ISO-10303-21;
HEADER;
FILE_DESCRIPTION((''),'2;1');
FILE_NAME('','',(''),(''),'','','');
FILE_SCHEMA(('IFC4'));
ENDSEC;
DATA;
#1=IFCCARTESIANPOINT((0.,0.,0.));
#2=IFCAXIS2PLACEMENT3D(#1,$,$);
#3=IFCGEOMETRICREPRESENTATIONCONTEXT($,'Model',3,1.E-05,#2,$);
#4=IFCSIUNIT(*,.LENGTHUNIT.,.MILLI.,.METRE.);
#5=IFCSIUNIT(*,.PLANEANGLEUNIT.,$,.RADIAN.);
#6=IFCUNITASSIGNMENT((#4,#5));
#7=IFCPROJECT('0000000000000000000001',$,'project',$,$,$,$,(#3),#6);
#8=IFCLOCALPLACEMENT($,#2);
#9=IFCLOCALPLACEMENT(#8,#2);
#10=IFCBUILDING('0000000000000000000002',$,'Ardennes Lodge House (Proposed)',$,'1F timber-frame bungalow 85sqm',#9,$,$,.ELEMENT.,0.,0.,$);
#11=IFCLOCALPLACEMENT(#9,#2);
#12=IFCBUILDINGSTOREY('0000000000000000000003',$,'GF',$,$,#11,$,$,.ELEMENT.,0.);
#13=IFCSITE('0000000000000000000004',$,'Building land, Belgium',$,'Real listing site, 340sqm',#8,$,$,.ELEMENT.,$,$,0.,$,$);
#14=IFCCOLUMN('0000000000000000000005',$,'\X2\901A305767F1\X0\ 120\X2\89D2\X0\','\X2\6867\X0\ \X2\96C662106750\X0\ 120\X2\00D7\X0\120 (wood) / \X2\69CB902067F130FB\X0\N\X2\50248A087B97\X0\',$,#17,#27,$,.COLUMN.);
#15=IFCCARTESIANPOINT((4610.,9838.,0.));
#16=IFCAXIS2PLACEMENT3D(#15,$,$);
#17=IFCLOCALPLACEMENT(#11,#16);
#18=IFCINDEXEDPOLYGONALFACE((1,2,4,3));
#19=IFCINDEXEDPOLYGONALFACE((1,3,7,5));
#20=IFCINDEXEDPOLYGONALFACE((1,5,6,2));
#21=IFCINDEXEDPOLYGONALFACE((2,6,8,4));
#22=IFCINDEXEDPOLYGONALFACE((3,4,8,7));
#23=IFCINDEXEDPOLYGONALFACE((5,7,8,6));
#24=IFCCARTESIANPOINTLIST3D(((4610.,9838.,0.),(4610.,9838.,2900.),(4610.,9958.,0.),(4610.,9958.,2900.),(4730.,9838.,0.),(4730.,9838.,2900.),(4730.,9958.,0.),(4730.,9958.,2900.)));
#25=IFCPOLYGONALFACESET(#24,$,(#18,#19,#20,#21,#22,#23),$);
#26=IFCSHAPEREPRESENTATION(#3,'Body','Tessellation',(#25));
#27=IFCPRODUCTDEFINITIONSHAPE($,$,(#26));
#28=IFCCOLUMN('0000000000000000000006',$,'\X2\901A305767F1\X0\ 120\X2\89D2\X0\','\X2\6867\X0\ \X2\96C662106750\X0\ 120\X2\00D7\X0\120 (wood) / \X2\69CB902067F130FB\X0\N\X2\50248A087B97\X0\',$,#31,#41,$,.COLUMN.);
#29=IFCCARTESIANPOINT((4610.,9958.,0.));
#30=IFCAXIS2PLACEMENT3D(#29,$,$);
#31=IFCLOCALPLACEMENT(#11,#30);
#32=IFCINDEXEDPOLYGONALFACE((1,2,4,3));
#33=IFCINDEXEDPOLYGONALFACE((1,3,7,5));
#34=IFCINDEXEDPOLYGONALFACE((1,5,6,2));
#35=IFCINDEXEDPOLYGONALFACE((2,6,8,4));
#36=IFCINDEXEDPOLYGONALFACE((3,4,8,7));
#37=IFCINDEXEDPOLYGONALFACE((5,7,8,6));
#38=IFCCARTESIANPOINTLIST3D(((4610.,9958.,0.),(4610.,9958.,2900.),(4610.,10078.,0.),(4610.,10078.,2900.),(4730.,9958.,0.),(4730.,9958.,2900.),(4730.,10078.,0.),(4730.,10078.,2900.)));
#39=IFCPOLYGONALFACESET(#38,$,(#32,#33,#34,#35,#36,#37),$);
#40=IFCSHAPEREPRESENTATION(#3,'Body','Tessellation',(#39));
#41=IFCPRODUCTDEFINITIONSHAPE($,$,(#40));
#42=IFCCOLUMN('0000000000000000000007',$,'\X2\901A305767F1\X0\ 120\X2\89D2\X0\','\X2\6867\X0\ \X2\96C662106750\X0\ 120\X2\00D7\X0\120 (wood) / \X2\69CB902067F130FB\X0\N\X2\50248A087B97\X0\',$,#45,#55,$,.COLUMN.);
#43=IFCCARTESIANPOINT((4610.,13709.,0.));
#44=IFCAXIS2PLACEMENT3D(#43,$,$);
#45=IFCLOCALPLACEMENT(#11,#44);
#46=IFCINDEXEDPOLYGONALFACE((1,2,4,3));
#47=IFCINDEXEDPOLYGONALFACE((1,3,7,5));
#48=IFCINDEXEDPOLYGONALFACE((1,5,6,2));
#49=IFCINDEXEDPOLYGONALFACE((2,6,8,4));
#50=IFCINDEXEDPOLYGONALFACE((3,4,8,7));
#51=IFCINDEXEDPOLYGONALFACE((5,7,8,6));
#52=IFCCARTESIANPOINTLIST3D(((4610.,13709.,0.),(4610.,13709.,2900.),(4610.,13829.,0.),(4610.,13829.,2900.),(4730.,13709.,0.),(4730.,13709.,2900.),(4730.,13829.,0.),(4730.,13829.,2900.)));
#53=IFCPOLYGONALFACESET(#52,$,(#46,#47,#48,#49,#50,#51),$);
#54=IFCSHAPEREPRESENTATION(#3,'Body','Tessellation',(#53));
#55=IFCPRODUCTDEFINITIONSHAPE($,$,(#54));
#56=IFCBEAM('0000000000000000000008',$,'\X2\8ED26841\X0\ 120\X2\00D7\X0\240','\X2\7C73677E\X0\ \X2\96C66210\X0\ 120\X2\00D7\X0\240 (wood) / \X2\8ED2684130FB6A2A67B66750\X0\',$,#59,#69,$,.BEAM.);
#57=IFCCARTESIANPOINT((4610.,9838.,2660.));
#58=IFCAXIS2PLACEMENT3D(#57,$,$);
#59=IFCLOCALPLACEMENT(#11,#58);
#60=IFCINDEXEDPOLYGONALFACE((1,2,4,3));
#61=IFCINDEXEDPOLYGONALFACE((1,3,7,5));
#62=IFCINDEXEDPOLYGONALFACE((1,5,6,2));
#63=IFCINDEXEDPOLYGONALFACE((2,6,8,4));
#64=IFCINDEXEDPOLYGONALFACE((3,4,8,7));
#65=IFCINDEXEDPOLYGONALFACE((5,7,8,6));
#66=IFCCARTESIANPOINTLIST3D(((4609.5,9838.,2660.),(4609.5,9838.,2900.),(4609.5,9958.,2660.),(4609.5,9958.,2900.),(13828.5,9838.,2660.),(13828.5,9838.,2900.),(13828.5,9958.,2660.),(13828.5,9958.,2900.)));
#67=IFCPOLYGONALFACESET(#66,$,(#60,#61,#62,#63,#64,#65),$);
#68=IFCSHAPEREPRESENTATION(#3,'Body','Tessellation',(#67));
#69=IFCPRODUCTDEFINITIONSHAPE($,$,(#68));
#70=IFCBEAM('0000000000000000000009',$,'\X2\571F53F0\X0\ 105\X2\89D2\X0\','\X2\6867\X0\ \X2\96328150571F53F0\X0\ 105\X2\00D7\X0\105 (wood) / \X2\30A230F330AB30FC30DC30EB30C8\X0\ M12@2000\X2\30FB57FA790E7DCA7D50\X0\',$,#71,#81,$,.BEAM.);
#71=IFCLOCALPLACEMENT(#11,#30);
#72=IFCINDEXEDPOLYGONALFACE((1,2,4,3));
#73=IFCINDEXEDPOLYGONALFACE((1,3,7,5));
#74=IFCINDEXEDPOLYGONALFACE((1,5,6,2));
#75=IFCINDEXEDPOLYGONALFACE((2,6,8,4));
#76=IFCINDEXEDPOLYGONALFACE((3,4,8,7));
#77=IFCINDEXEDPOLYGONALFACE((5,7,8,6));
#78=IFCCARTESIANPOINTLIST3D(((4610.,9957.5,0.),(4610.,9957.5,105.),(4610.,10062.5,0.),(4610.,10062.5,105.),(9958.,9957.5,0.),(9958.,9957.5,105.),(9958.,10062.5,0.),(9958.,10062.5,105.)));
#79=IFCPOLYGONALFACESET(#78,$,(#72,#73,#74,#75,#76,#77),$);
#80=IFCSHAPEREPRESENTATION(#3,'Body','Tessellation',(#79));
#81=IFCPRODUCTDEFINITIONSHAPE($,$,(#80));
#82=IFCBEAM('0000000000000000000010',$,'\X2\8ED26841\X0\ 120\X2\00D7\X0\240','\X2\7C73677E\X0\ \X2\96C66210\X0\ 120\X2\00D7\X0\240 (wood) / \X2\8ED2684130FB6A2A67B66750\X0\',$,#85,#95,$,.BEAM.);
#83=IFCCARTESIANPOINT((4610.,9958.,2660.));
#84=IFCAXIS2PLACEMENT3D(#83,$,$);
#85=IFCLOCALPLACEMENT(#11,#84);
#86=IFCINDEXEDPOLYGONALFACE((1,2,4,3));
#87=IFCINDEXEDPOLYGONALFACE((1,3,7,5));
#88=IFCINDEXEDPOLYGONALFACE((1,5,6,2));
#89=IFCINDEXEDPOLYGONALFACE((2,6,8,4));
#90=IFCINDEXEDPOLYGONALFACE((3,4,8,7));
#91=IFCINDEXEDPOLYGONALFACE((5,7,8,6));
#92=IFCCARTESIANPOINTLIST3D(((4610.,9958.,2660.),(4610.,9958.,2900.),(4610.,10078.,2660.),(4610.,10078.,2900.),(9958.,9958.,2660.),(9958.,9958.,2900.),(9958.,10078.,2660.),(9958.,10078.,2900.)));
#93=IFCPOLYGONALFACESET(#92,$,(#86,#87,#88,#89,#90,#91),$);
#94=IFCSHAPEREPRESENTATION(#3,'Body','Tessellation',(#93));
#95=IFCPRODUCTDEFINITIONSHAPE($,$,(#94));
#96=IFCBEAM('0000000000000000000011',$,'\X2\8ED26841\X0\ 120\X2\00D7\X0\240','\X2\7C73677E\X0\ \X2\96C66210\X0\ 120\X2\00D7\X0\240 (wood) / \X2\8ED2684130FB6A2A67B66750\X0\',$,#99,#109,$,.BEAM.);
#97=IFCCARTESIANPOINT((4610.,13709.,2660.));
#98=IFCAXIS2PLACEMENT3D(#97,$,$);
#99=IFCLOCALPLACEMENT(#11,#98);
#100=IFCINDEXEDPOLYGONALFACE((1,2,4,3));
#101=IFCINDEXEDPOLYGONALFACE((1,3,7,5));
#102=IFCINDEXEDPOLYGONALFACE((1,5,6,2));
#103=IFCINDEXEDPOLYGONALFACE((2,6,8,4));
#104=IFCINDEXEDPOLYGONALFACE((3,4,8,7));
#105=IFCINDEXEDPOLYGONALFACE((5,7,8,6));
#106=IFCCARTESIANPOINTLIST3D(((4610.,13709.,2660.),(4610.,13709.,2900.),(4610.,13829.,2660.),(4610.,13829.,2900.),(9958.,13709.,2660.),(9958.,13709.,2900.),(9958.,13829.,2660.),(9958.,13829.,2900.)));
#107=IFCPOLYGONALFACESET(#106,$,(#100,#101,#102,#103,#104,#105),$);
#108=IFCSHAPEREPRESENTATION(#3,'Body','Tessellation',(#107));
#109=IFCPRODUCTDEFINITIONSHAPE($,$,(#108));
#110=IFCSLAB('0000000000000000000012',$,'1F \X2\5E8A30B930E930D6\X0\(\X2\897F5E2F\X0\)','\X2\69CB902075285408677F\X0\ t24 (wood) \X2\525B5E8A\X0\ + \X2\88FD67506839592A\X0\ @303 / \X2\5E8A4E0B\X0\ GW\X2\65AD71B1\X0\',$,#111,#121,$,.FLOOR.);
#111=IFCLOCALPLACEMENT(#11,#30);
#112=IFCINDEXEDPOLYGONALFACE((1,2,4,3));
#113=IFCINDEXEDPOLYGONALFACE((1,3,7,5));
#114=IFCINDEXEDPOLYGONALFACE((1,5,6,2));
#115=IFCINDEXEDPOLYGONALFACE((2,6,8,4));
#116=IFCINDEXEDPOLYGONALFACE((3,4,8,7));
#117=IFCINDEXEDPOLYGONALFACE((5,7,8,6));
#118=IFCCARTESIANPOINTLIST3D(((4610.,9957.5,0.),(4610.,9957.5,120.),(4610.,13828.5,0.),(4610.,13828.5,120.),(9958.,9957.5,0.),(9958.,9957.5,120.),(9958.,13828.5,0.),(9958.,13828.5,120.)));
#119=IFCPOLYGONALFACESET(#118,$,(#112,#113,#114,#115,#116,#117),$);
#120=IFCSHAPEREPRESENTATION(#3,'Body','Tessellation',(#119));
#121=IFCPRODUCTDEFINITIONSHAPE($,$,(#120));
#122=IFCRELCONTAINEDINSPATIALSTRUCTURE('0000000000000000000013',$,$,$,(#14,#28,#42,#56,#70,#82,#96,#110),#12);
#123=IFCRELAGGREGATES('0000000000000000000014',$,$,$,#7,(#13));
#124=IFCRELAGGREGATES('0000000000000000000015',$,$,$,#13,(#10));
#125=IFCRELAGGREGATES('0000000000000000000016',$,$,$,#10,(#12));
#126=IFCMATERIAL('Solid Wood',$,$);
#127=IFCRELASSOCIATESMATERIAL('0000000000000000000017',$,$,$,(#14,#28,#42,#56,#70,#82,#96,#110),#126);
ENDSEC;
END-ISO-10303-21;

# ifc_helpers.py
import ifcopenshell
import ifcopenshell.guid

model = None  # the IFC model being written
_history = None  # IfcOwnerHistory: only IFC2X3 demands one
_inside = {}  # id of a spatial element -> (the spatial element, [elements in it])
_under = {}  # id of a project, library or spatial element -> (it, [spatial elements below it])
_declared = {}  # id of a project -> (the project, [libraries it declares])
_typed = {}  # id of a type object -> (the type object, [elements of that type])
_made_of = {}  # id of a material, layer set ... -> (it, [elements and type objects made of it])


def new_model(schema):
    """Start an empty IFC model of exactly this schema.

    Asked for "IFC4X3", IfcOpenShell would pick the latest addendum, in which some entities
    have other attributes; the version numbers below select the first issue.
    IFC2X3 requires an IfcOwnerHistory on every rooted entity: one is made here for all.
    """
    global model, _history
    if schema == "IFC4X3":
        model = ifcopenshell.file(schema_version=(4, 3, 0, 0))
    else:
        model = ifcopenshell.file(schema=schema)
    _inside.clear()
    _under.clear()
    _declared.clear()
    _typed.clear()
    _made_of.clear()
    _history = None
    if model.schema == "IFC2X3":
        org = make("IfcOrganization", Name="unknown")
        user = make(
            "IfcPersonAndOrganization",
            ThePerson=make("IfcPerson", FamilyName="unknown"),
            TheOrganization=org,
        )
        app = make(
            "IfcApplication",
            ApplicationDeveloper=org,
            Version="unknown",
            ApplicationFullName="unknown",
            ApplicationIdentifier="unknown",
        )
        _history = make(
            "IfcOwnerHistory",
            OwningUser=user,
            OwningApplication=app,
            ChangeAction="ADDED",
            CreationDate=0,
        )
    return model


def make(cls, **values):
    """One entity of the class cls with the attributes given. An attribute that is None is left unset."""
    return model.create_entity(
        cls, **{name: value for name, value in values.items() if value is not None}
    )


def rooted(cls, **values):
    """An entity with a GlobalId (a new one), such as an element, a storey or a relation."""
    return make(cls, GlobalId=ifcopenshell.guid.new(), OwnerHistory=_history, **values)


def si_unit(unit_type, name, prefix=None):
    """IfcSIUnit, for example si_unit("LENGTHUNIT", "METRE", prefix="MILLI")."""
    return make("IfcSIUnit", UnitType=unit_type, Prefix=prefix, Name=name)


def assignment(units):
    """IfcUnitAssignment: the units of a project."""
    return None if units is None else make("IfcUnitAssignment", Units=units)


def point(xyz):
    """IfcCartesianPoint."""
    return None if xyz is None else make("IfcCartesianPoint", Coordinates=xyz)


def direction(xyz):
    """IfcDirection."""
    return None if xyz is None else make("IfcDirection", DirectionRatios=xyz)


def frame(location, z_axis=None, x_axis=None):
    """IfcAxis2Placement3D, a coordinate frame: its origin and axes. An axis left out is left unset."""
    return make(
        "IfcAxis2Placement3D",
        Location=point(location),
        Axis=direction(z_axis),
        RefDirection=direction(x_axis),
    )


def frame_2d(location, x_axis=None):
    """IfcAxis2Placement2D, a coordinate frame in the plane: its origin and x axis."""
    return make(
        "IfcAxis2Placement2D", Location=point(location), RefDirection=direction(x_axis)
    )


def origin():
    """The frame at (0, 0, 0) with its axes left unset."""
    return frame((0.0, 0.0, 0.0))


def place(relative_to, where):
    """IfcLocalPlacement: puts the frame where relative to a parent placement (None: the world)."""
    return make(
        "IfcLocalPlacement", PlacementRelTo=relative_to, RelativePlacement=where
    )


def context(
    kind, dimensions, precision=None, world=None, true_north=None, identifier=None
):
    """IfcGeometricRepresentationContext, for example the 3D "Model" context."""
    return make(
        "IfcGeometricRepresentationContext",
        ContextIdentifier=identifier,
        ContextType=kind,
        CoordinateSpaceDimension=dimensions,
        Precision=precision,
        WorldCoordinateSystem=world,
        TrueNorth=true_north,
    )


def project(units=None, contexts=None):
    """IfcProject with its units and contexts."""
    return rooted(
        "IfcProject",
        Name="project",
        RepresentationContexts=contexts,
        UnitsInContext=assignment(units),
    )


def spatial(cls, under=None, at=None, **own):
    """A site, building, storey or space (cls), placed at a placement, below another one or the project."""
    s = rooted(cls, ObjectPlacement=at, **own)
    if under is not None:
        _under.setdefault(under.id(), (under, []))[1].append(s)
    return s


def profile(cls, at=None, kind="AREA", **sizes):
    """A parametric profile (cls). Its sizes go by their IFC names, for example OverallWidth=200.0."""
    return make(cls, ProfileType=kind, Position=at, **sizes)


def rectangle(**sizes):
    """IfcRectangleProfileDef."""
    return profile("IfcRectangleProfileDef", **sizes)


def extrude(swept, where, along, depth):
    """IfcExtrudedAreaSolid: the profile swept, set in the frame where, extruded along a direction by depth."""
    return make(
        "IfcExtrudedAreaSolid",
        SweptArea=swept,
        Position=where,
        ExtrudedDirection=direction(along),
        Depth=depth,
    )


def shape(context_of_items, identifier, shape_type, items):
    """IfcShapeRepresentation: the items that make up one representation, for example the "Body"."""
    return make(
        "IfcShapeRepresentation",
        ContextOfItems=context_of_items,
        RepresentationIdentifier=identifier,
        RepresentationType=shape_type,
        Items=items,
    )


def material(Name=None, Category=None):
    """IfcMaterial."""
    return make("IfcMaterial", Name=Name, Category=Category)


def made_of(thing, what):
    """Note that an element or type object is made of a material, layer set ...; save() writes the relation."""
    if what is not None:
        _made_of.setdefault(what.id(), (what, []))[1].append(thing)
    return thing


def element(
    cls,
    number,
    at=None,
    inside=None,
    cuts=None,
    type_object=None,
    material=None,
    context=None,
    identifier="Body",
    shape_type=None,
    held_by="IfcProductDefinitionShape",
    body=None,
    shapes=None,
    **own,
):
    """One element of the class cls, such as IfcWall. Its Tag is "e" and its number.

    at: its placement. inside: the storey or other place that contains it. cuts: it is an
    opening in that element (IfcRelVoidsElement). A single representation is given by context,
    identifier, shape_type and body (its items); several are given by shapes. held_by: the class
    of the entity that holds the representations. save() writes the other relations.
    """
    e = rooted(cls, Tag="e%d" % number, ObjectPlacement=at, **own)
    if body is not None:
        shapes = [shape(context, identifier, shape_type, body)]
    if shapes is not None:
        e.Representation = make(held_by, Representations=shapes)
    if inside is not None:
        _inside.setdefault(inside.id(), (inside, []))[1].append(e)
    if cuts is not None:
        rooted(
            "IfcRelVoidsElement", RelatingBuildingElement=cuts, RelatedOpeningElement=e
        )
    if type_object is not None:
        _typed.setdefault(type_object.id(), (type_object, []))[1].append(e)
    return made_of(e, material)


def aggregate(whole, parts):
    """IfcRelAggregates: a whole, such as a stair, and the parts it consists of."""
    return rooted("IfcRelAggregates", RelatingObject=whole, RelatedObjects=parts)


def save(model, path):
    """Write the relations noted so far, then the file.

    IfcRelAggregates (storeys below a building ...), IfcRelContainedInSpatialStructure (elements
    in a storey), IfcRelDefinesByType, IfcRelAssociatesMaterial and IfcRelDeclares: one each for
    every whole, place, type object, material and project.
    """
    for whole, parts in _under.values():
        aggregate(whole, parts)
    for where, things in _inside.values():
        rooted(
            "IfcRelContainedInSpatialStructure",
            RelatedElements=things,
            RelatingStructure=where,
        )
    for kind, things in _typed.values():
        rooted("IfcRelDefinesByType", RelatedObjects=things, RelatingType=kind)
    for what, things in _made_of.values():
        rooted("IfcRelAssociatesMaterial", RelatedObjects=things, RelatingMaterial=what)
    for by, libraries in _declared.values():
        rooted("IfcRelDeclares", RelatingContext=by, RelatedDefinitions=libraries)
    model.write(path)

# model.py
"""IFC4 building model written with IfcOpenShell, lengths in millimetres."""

from ifc_helpers import new_model, si_unit, frame, frame_2d, origin, place, context, project, spatial, rectangle, extrude, material, element, save


model = new_model("IFC4")

# Units and contexts
model_context = context("Model", 3, precision=1e-05, world=origin())
ifc_project = project(units=[si_unit("LENGTHUNIT", "METRE", prefix="MILLI"), si_unit("PLANEANGLEUNIT", "RADIAN")], contexts=[model_context])

# Site, building, storey
site_placement = place(None, origin())
site = spatial("IfcSite", under=ifc_project, at=site_placement, Name="Building land, Belgium", ObjectType="Real listing site, 340sqm", CompositionType="ELEMENT", RefElevation=0.0)
building_placement = place(site_placement, origin())
building = spatial("IfcBuilding", under=site, at=building_placement, Name="Ardennes Lodge House (Proposed)", ObjectType="1F timber-frame bungalow 85sqm", CompositionType="ELEMENT", ElevationOfRefHeight=0.0, ElevationOfTerrain=0.0)
storey_placement = place(building_placement, origin())
storey = spatial("IfcBuildingStorey", under=building, at=storey_placement, Name="GF", CompositionType="ELEMENT", Elevation=0.0)

# Columns
ifc_material_1 = material(Name="Solid Wood")
column_1_placement = place(storey_placement, frame((4610.0, 9838.0, 0.0)))
element("IfcColumn", 1, at=column_1_placement, inside=storey, material=ifc_material_1, Name="通し柱 120角", Description="桧 集成材 120×120 (wood) / 構造柱・N値計算", PredefinedType="COLUMN", context=model_context, shape_type="SweptSolid", body=[
    extrude(rectangle(XDim=120.0, YDim=120.0, at=frame_2d((60.0, 60.0))), frame((4610.0, 9838.0, 0.0)), (0.0, 0.0, 1.0), 2900.0),
])
column_2_placement = place(storey_placement, frame((4610.0, 9958.0, 0.0)))
element("IfcColumn", 2, at=column_2_placement, inside=storey, material=ifc_material_1, Name="通し柱 120角", Description="桧 集成材 120×120 (wood) / 構造柱・N値計算", PredefinedType="COLUMN", context=model_context, shape_type="SweptSolid", body=[
    extrude(rectangle(XDim=120.0, YDim=120.0, at=frame_2d((60.0, 60.0))), frame((4610.0, 9958.0, 0.0)), (0.0, 0.0, 1.0), 2900.0),
])
column_3_placement = place(storey_placement, frame((4610.0, 13709.0, 0.0)))
element("IfcColumn", 3, at=column_3_placement, inside=storey, material=ifc_material_1, Name="通し柱 120角", Description="桧 集成材 120×120 (wood) / 構造柱・N値計算", PredefinedType="COLUMN", context=model_context, shape_type="SweptSolid", body=[
    extrude(rectangle(XDim=120.0, YDim=120.0, at=frame_2d((60.0, 60.0))), frame((4610.0, 13709.0, 0.0)), (0.0, 0.0, 1.0), 2900.0),
])

# Beams
beam_1_placement = place(storey_placement, frame((4610.0, 9838.0, 2660.0)))
element("IfcBeam", 4, at=beam_1_placement, inside=storey, material=ifc_material_1, Name="軒桁 120×240", Description="米松 集成 120×240 (wood) / 軒桁・横架材", PredefinedType="BEAM", context=model_context, shape_type="SweptSolid", body=[
    extrude(rectangle(XDim=9219.0, YDim=120.0, at=frame_2d((4609.0, 60.0))), frame((4610.0, 9838.0, 2660.0)), (0.0, 0.0, 1.0), 240.0),
])
beam_2_placement = place(storey_placement, frame((4610.0, 9958.0, 0.0)))
element("IfcBeam", 5, at=beam_2_placement, inside=storey, material=ifc_material_1, Name="土台 105角", Description="桧 防腐土台 105×105 (wood) / アンカーボルト M12@2000・基礎緊結", PredefinedType="BEAM", context=model_context, shape_type="SweptSolid", body=[
    extrude(rectangle(XDim=5348.0, YDim=105.0, at=frame_2d((2674.0, 52.0))), frame((4610.0, 9958.0, 0.0)), (0.0, 0.0, 1.0), 105.0),
])
beam_3_placement = place(storey_placement, frame((4610.0, 9958.0, 2660.0)))
element("IfcBeam", 6, at=beam_3_placement, inside=storey, material=ifc_material_1, Name="軒桁 120×240", Description="米松 集成 120×240 (wood) / 軒桁・横架材", PredefinedType="BEAM", context=model_context, shape_type="SweptSolid", body=[
    extrude(rectangle(XDim=5348.0, YDim=120.0, at=frame_2d((2674.0, 60.0))), frame((4610.0, 9958.0, 2660.0)), (0.0, 0.0, 1.0), 240.0),
])
beam_4_placement = place(storey_placement, frame((4610.0, 13709.0, 2660.0)))
element("IfcBeam", 7, at=beam_4_placement, inside=storey, material=ifc_material_1, Name="軒桁 120×240", Description="米松 集成 120×240 (wood) / 軒桁・横架材", PredefinedType="BEAM", context=model_context, shape_type="SweptSolid", body=[
    extrude(rectangle(XDim=5348.0, YDim=120.0, at=frame_2d((2674.0, 60.0))), frame((4610.0, 13709.0, 2660.0)), (0.0, 0.0, 1.0), 240.0),
])

# Slab
slab_placement = place(storey_placement, frame((4610.0, 9958.0, 0.0)))
element("IfcSlab", 8, at=slab_placement, inside=storey, material=ifc_material_1, Name="1F 床スラブ(西帯)", Description="構造用合板 t24 (wood) 剛床 + 製材根太 @303 / 床下 GW断熱", PredefinedType="FLOOR", context=model_context, shape_type="SweptSolid", body=[
    extrude(rectangle(XDim=5348.0, YDim=3871.0, at=frame_2d((2674.0, 1935.0))), frame((4610.0, 9958.0, 0.0)), (0.0, 0.0, 1.0), 120.0),
])

save(model, "model.ifc")
